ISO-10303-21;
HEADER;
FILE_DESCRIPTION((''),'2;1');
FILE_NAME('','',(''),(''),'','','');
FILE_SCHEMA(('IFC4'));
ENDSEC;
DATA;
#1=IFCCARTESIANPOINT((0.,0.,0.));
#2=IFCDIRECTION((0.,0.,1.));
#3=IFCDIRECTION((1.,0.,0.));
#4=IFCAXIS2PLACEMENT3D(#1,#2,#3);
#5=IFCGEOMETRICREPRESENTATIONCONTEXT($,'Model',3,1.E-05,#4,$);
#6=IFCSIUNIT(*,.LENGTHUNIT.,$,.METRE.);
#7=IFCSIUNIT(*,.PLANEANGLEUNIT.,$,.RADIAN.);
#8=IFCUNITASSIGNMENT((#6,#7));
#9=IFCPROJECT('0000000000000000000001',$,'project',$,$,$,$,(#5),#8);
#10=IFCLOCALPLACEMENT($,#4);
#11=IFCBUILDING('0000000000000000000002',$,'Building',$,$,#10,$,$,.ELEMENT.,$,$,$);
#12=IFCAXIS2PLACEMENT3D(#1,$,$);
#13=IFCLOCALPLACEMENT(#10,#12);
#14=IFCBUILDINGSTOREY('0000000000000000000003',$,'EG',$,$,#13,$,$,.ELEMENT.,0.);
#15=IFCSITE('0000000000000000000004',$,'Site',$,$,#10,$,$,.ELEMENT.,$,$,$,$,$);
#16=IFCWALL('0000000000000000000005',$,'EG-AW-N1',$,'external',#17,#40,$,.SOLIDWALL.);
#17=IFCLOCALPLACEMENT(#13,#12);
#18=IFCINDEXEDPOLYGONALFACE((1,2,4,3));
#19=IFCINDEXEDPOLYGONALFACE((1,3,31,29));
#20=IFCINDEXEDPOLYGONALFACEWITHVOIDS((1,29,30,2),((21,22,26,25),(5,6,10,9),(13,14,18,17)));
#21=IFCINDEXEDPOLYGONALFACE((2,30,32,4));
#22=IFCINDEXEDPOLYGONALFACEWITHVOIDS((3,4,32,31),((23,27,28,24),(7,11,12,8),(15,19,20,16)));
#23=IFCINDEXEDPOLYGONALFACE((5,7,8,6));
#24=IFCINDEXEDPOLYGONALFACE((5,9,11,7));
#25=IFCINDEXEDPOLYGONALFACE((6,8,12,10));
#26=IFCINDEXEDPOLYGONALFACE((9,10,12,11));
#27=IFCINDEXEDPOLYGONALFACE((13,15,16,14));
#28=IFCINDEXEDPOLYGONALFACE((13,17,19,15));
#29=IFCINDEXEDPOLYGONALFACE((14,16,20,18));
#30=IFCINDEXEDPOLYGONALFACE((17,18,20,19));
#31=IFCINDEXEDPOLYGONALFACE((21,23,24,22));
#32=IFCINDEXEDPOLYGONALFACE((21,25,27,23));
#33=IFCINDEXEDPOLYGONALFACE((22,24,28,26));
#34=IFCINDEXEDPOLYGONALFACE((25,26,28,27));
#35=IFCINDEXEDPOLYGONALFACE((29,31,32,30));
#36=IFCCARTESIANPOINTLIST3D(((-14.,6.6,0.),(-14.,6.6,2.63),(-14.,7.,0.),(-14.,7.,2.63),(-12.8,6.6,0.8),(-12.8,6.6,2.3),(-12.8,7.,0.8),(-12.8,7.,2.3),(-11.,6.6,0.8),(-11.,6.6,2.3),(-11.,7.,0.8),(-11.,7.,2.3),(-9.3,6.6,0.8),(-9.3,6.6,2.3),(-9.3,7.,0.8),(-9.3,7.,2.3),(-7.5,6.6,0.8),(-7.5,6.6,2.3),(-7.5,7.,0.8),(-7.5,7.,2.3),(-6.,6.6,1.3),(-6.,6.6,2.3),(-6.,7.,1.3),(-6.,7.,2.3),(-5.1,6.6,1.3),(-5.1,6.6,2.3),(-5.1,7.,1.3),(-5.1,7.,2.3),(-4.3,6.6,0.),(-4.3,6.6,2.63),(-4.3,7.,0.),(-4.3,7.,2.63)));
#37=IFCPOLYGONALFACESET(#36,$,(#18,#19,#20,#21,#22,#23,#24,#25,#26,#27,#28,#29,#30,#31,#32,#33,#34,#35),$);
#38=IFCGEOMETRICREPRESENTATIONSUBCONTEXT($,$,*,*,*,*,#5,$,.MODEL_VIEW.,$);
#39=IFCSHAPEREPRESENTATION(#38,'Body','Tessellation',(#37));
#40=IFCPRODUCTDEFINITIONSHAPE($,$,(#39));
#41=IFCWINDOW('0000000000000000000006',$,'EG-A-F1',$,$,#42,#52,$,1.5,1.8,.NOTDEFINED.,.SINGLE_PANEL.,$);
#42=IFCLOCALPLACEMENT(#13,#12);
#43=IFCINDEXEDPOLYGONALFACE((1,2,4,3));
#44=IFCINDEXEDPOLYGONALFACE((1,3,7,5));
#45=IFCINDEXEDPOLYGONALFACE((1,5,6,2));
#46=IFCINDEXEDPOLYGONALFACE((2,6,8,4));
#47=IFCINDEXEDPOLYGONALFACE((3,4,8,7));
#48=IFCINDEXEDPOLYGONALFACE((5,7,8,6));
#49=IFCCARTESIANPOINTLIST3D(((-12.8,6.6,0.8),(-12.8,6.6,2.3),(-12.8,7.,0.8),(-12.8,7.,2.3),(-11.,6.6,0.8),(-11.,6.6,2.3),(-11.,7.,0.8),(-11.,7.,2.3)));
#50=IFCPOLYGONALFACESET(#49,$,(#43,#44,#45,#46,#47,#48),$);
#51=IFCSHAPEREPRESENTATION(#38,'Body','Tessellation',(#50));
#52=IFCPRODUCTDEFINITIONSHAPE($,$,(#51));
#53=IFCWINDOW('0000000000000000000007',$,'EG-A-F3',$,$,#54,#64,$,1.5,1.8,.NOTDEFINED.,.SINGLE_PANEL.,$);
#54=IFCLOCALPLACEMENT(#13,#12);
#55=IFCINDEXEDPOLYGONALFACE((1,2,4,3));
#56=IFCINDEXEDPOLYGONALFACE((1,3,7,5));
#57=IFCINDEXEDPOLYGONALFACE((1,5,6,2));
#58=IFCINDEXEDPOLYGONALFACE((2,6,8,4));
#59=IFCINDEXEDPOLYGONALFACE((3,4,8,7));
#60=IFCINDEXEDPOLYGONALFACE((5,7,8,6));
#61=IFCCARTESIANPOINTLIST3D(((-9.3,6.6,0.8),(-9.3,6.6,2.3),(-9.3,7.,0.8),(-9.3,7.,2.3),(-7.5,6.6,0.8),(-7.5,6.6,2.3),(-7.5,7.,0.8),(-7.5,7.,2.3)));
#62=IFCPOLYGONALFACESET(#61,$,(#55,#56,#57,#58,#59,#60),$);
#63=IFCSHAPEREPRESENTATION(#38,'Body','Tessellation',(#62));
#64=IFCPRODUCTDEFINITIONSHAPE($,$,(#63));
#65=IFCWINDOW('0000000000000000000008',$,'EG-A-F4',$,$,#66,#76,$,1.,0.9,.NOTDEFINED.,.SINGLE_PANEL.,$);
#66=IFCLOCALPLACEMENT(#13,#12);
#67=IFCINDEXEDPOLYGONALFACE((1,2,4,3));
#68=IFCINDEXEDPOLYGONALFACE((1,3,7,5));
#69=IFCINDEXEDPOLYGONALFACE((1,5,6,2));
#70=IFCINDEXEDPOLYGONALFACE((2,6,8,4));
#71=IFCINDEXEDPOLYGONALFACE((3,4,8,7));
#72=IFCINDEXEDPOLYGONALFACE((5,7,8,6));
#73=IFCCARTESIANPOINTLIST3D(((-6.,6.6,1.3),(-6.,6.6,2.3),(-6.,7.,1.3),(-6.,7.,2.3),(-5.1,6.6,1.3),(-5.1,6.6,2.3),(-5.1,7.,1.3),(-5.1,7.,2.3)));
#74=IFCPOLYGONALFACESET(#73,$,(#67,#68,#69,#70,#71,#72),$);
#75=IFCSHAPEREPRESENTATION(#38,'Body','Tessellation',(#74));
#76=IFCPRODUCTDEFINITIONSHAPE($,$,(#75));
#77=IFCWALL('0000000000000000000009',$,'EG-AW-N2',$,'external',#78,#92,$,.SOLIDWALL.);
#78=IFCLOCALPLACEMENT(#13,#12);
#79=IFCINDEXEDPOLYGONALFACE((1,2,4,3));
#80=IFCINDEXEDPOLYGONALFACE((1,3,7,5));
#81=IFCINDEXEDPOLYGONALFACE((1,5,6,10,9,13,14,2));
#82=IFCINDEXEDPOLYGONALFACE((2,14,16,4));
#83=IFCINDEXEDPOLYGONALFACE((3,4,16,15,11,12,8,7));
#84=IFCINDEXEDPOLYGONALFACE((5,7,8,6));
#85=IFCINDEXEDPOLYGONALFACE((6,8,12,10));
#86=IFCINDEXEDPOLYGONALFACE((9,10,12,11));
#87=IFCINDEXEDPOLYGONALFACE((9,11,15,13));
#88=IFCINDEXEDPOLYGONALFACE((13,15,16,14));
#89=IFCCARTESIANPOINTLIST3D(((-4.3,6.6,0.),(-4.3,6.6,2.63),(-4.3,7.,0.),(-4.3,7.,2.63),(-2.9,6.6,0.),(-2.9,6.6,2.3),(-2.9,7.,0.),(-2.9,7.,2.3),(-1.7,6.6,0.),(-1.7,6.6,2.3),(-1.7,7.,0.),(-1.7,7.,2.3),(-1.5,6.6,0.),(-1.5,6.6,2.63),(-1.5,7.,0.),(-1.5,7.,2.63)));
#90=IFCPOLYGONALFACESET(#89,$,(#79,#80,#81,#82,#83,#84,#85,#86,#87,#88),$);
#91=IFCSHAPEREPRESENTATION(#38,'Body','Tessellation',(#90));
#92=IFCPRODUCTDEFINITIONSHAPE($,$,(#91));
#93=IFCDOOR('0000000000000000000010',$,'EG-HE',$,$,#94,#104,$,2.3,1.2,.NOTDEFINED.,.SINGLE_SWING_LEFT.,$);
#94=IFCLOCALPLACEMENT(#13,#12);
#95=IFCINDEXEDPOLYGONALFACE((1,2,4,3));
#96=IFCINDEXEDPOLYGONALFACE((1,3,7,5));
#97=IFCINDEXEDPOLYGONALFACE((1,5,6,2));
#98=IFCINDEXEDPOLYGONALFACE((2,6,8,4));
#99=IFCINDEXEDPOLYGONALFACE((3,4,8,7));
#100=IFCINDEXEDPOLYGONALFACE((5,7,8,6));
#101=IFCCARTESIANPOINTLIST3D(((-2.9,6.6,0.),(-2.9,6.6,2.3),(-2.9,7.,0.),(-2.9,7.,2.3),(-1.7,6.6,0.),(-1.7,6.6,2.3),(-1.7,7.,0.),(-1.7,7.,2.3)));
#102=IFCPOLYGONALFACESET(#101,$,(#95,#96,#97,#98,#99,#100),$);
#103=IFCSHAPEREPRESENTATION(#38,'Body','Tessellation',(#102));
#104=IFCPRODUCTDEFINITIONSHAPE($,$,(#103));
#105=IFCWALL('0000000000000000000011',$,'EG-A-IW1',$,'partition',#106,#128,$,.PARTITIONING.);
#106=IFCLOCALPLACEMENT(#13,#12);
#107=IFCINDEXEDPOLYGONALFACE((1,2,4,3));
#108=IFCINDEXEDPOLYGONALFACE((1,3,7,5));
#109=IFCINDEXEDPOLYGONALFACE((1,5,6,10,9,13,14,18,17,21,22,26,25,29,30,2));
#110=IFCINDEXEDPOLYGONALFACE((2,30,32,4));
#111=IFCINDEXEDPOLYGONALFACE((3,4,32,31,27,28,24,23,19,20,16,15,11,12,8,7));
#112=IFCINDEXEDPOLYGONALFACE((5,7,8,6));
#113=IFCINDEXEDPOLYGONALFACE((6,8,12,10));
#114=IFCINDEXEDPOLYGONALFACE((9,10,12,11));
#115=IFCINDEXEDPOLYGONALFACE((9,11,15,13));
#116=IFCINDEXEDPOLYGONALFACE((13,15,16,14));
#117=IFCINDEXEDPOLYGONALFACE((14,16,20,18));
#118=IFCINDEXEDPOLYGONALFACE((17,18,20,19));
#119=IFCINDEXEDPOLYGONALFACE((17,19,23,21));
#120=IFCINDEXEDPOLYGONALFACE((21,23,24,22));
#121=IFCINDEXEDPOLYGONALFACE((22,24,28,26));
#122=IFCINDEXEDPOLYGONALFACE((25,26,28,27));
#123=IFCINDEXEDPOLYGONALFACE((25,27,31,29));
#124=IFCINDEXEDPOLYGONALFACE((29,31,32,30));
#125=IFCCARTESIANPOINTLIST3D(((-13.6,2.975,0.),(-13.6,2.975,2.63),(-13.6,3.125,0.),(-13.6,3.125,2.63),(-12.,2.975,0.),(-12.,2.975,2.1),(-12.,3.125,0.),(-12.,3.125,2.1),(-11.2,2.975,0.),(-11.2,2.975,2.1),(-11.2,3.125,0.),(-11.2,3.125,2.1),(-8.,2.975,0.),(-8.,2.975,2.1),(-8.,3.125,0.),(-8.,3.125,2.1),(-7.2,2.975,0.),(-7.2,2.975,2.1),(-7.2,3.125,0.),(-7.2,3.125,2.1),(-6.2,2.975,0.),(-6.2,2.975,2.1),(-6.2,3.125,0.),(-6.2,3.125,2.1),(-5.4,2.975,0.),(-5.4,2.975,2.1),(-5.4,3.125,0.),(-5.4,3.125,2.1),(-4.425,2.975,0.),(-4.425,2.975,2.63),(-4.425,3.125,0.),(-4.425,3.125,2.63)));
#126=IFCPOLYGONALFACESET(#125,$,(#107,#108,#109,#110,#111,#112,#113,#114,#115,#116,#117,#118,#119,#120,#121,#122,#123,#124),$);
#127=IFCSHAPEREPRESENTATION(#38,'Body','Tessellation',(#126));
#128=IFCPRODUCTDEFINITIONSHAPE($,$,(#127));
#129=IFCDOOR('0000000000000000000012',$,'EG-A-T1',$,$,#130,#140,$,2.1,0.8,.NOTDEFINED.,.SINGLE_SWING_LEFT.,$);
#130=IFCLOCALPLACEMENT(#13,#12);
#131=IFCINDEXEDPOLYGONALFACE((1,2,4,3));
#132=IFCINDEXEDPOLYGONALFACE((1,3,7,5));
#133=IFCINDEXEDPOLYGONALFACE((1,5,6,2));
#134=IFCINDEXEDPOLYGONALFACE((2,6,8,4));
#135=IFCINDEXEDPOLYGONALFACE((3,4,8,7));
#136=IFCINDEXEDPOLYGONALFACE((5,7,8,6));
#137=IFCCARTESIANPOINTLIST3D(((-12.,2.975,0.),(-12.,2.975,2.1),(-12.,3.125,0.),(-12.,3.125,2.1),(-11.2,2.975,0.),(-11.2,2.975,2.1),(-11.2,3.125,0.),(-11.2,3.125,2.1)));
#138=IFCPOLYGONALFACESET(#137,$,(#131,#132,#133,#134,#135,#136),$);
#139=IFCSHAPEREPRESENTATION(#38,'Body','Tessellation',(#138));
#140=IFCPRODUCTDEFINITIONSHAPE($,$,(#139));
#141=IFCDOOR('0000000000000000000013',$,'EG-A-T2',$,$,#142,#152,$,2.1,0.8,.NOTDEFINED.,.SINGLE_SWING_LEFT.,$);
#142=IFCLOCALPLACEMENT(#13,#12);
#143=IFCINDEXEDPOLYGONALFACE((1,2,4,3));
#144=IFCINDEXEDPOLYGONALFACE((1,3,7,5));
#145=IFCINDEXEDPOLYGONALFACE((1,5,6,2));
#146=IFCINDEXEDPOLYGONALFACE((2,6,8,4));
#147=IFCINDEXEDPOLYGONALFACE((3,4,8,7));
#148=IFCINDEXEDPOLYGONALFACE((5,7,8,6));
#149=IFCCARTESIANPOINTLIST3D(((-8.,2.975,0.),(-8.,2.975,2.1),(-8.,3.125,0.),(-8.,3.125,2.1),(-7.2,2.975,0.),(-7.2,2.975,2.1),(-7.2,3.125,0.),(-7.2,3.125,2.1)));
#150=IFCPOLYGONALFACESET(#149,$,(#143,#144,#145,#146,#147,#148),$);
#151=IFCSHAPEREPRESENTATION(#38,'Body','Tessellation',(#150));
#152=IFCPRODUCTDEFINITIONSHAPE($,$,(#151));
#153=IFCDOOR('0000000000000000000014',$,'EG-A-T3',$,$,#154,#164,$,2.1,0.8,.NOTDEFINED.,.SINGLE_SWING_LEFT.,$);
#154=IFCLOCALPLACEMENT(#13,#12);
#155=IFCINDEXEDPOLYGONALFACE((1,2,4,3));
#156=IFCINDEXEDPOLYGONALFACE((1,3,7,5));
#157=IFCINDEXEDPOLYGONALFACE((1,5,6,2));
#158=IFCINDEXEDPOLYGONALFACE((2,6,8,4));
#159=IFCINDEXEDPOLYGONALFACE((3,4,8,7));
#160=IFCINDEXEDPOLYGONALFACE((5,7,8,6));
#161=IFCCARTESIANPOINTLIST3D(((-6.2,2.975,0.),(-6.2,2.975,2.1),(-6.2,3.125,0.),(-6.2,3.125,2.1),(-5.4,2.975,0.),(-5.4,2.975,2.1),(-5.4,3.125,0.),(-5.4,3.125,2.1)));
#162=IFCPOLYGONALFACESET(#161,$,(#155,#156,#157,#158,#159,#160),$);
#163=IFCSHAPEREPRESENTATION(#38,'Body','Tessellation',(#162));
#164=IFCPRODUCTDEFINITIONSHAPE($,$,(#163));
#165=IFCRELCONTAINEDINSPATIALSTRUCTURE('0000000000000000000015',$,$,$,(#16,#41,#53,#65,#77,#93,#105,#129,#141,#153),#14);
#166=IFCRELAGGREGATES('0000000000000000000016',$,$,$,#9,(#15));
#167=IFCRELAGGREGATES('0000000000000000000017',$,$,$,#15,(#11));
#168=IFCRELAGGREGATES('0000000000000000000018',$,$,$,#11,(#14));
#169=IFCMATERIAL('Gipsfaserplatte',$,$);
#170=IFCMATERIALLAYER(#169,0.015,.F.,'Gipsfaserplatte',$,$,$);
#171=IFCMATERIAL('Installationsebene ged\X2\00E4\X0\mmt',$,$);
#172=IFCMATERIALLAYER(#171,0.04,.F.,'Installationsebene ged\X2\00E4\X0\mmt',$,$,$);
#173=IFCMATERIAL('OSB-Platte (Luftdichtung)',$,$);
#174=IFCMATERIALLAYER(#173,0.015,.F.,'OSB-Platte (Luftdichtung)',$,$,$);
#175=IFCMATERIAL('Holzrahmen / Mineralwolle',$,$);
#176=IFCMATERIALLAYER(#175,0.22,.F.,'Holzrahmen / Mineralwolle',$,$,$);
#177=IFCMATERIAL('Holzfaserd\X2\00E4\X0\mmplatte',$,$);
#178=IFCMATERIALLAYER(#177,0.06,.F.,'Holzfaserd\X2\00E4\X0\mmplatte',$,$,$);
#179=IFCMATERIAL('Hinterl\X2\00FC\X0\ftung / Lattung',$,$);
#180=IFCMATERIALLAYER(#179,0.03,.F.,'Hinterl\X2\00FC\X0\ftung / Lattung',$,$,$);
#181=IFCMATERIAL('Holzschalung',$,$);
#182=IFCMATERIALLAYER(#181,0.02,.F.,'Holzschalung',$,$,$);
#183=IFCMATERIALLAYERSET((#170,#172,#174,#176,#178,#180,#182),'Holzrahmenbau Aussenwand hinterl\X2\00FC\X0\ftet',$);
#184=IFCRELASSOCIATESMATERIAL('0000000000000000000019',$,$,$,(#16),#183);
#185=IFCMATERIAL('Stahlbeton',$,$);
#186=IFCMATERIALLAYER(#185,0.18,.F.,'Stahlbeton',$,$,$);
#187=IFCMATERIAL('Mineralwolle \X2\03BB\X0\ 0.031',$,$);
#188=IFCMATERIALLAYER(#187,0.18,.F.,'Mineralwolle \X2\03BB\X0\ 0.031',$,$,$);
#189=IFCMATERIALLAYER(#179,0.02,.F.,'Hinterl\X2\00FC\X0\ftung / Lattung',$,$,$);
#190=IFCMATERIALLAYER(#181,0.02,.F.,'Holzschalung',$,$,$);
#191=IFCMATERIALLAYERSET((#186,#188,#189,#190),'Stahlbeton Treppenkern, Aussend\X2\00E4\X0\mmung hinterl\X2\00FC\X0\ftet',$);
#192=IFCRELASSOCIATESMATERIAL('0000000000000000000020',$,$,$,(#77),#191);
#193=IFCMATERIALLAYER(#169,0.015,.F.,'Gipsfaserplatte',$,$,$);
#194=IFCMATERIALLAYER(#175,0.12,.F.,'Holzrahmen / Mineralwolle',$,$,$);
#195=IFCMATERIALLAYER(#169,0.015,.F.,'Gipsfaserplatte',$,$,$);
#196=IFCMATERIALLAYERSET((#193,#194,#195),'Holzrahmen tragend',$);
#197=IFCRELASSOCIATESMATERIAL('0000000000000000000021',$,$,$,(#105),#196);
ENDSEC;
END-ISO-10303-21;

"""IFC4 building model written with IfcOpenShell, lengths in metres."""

from ifc_helpers import new_model, si_unit, frame, frame_2d, origin, origin_with_axes, place, context, subcontext, project, spatial, rectangle, extrude, material, layer, layer_set, element, fill, save


model = new_model("IFC4")

# Units and contexts
model_context = context("Model", 3, precision=1e-05, world=origin_with_axes())
sub_context = subcontext(model_context, None, None, "MODEL_VIEW")
ifc_project = project(units=[si_unit("LENGTHUNIT", "METRE"), si_unit("PLANEANGLEUNIT", "RADIAN")], contexts=[model_context])

# Site, building, storey
placement = place(None, origin_with_axes())
site = spatial("IfcSite", under=ifc_project, at=placement, Name="Site", CompositionType="ELEMENT")
building = spatial("IfcBuilding", under=site, at=placement, Name="Building", CompositionType="ELEMENT")
storey_placement = place(placement, origin())
storey = spatial("IfcBuildingStorey", under=building, at=storey_placement, Name="EG", CompositionType="ELEMENT", Elevation=0.0)

# Wall, openings, windows
ifc_material_1 = material(Name="Gipsfaserplatte")
ifc_layer_1 = layer(ifc_material_1, 0.015, ventilated=False, Name="Gipsfaserplatte")
ifc_material_2 = material(Name="Installationsebene gedämmt")
ifc_layer_2 = layer(ifc_material_2, 0.04, ventilated=False, Name="Installationsebene gedämmt")
ifc_material_3 = material(Name="OSB-Platte (Luftdichtung)")
ifc_layer_3 = layer(ifc_material_3, 0.015, ventilated=False, Name="OSB-Platte (Luftdichtung)")
ifc_material_4 = material(Name="Holzrahmen / Mineralwolle")
ifc_layer_4 = layer(ifc_material_4, 0.22, ventilated=False, Name="Holzrahmen / Mineralwolle")
ifc_material_5 = material(Name="Holzfaserdämmplatte")
ifc_layer_5 = layer(ifc_material_5, 0.06, ventilated=False, Name="Holzfaserdämmplatte")
ifc_material_6 = material(Name="Hinterlüftung / Lattung")
ifc_layer_6 = layer(ifc_material_6, 0.03, ventilated=False, Name="Hinterlüftung / Lattung")
ifc_material_7 = material(Name="Holzschalung")
ifc_layer_7 = layer(ifc_material_7, 0.02, ventilated=False, Name="Holzschalung")
ifc_layer_set_1 = layer_set([ifc_layer_1, ifc_layer_2, ifc_layer_3, ifc_layer_4, ifc_layer_5, ifc_layer_6, ifc_layer_7], Name="Holzrahmenbau Aussenwand hinterlüftet")
wall_1_placement = place(storey_placement, frame((-14.0, 6.8, 0.0), z_axis=(0.0, 0.0, 1.0), x_axis=(1.0, 0.0, 0.0)))
wall_1 = element("IfcWall", 1, at=wall_1_placement, inside=storey, material=ifc_layer_set_1, Name="EG-AW-N1", ObjectType="external", PredefinedType="SOLIDWALL", context=sub_context, shape_type="SweptSolid", body=[
    extrude(rectangle(XDim=9.7, YDim=0.4, at=frame_2d((4.85, 0.0))), origin(), (0.0, 0.0, 1.0), 2.63),
])
opening_1_placement = place(wall_1_placement, frame((2.1, 0.25, 0.8), z_axis=(0.0, -1.0, 0.0), x_axis=(1.0, 0.0, 0.0)))
opening_1 = element("IfcOpeningElement", 2, at=opening_1_placement, cuts=wall_1, PredefinedType="OPENING", context=sub_context, shape_type="SweptSolid", body=[
    extrude(rectangle(XDim=1.8, YDim=1.5, at=frame_2d((0.0, 0.75))), origin(), (0.0, 0.0, 1.0), 0.5),
])
opening_2_placement = place(wall_1_placement, frame((5.6, 0.25, 0.8), z_axis=(0.0, -1.0, 0.0), x_axis=(1.0, 0.0, 0.0)))
opening_2 = element("IfcOpeningElement", 3, at=opening_2_placement, cuts=wall_1, PredefinedType="OPENING", context=sub_context, shape_type="SweptSolid", body=[
    extrude(rectangle(XDim=1.8, YDim=1.5, at=frame_2d((0.0, 0.75))), origin(), (0.0, 0.0, 1.0), 0.5),
])
opening_3_placement = place(wall_1_placement, frame((8.45, 0.25, 1.3), z_axis=(0.0, -1.0, 0.0), x_axis=(1.0, 0.0, 0.0)))
opening_3 = element("IfcOpeningElement", 4, at=opening_3_placement, cuts=wall_1, PredefinedType="OPENING", context=sub_context, shape_type="SweptSolid", body=[
    extrude(rectangle(XDim=0.9, YDim=1.0, at=frame_2d((0.0, 0.5))), origin(), (0.0, 0.0, 1.0), 0.5),
])
window_1_placement = place(wall_1_placement, frame((2.1, 0.2, 0.8), z_axis=(0.0, -1.0, 0.0), x_axis=(1.0, 0.0, 0.0)))
window_1 = element("IfcWindow", 5, at=window_1_placement, inside=storey, Name="EG-A-F1", OverallHeight=1.5, OverallWidth=1.8, PartitioningType="SINGLE_PANEL", PredefinedType="NOTDEFINED", context=sub_context, shape_type="SweptSolid", body=[
    extrude(rectangle(XDim=1.8, YDim=1.5, at=frame_2d((0.0, 0.75))), origin(), (0.0, 0.0, 1.0), 0.4),
])
fill(opening_1, window_1)
window_2_placement = place(wall_1_placement, frame((5.6, 0.2, 0.8), z_axis=(0.0, -1.0, 0.0), x_axis=(1.0, 0.0, 0.0)))
window_2 = element("IfcWindow", 6, at=window_2_placement, inside=storey, Name="EG-A-F3", OverallHeight=1.5, OverallWidth=1.8, PartitioningType="SINGLE_PANEL", PredefinedType="NOTDEFINED", context=sub_context, shape_type="SweptSolid", body=[
    extrude(rectangle(XDim=1.8, YDim=1.5, at=frame_2d((0.0, 0.75))), origin(), (0.0, 0.0, 1.0), 0.4),
])
fill(opening_2, window_2)
window_3_placement = place(wall_1_placement, frame((8.45, 0.2, 1.3), z_axis=(0.0, -1.0, 0.0), x_axis=(1.0, 0.0, 0.0)))
window_3 = element("IfcWindow", 7, at=window_3_placement, inside=storey, Name="EG-A-F4", OverallHeight=1.0, OverallWidth=0.9, PartitioningType="SINGLE_PANEL", PredefinedType="NOTDEFINED", context=sub_context, shape_type="SweptSolid", body=[
    extrude(rectangle(XDim=0.9, YDim=1.0, at=frame_2d((0.0, 0.5))), origin(), (0.0, 0.0, 1.0), 0.4),
])
fill(opening_3, window_3)

# Wall, opening, door
ifc_material_8 = material(Name="Stahlbeton")
ifc_layer_8 = layer(ifc_material_8, 0.18, ventilated=False, Name="Stahlbeton")
ifc_material_9 = material(Name="Mineralwolle λ 0.031")
ifc_layer_9 = layer(ifc_material_9, 0.18, ventilated=False, Name="Mineralwolle λ 0.031")
ifc_layer_10 = layer(ifc_material_6, 0.02, ventilated=False, Name="Hinterlüftung / Lattung")
ifc_layer_11 = layer(ifc_material_7, 0.02, ventilated=False, Name="Holzschalung")
ifc_layer_set_2 = layer_set([ifc_layer_8, ifc_layer_9, ifc_layer_10, ifc_layer_11], Name="Stahlbeton Treppenkern, Aussendämmung hinterlüftet")
wall_2_placement = place(storey_placement, frame((-4.3, 6.8, 0.0), z_axis=(0.0, 0.0, 1.0), x_axis=(1.0, 0.0, 0.0)))
wall_2 = element("IfcWall", 8, at=wall_2_placement, inside=storey, material=ifc_layer_set_2, Name="EG-AW-N2", ObjectType="external", PredefinedType="SOLIDWALL", context=sub_context, shape_type="SweptSolid", body=[
    extrude(rectangle(XDim=2.8, YDim=0.4, at=frame_2d((1.4, 0.0))), origin(), (0.0, 0.0, 1.0), 2.63),
])
opening_4_placement = place(wall_2_placement, frame((2.0, 0.25, 0.0), z_axis=(0.0, -1.0, 0.0), x_axis=(1.0, 0.0, 0.0)))
opening_4 = element("IfcOpeningElement", 9, at=opening_4_placement, cuts=wall_2, PredefinedType="OPENING", context=sub_context, shape_type="SweptSolid", body=[
    extrude(rectangle(XDim=1.2, YDim=2.3, at=frame_2d((0.0, 1.15))), origin(), (0.0, 0.0, 1.0), 0.5),
])
door_1_placement = place(wall_2_placement, frame((2.0, 0.2, 0.0), z_axis=(0.0, -1.0, 0.0), x_axis=(1.0, 0.0, 0.0)))
door_1 = element("IfcDoor", 10, at=door_1_placement, inside=storey, Name="EG-HE", OperationType="SINGLE_SWING_LEFT", OverallHeight=2.3, OverallWidth=1.2, PredefinedType="NOTDEFINED", context=sub_context, shape_type="SweptSolid", body=[
    extrude(rectangle(XDim=1.2, YDim=2.3, at=frame_2d((0.0, 1.15))), origin(), (0.0, 0.0, 1.0), 0.4),
])
fill(opening_4, door_1)

# Wall, openings, doors
ifc_layer_12 = layer(ifc_material_1, 0.015, ventilated=False, Name="Gipsfaserplatte")
ifc_layer_13 = layer(ifc_material_4, 0.12, ventilated=False, Name="Holzrahmen / Mineralwolle")
ifc_layer_14 = layer(ifc_material_1, 0.015, ventilated=False, Name="Gipsfaserplatte")
ifc_layer_set_3 = layer_set([ifc_layer_12, ifc_layer_13, ifc_layer_14], Name="Holzrahmen tragend")
wall_3_placement = place(storey_placement, frame((-13.6, 3.05, 0.0), z_axis=(0.0, 0.0, 1.0), x_axis=(1.0, 0.0, 0.0)))
wall_3 = element("IfcWall", 11, at=wall_3_placement, inside=storey, material=ifc_layer_set_3, Name="EG-A-IW1", ObjectType="partition", PredefinedType="PARTITIONING", context=sub_context, shape_type="SweptSolid", body=[
    extrude(rectangle(XDim=9.175, YDim=0.15, at=frame_2d((4.5875, 0.0))), origin(), (0.0, 0.0, 1.0), 2.63),
])
opening_5_placement = place(wall_3_placement, frame((2.0, 0.125, 0.0), z_axis=(0.0, -1.0, 0.0), x_axis=(1.0, 0.0, 0.0)))
opening_5 = element("IfcOpeningElement", 12, at=opening_5_placement, cuts=wall_3, PredefinedType="OPENING", context=sub_context, shape_type="SweptSolid", body=[
    extrude(rectangle(XDim=0.8, YDim=2.1, at=frame_2d((0.0, 1.05))), origin(), (0.0, 0.0, 1.0), 0.25),
])
opening_6_placement = place(wall_3_placement, frame((6.0, 0.125, 0.0), z_axis=(0.0, -1.0, 0.0), x_axis=(1.0, 0.0, 0.0)))
opening_6 = element("IfcOpeningElement", 13, at=opening_6_placement, cuts=wall_3, PredefinedType="OPENING", context=sub_context, shape_type="SweptSolid", body=[
    extrude(rectangle(XDim=0.8, YDim=2.1, at=frame_2d((0.0, 1.05))), origin(), (0.0, 0.0, 1.0), 0.25),
])
opening_7_placement = place(wall_3_placement, frame((7.8, 0.125, 0.0), z_axis=(0.0, -1.0, 0.0), x_axis=(1.0, 0.0, 0.0)))
opening_7 = element("IfcOpeningElement", 14, at=opening_7_placement, cuts=wall_3, PredefinedType="OPENING", context=sub_context, shape_type="SweptSolid", body=[
    extrude(rectangle(XDim=0.8, YDim=2.1, at=frame_2d((0.0, 1.05))), origin(), (0.0, 0.0, 1.0), 0.25),
])
door_2_placement = place(wall_3_placement, frame((2.0, 0.075, 0.0), z_axis=(0.0, -1.0, 0.0), x_axis=(1.0, 0.0, 0.0)))
door_2 = element("IfcDoor", 15, at=door_2_placement, inside=storey, Name="EG-A-T1", OperationType="SINGLE_SWING_LEFT", OverallHeight=2.1, OverallWidth=0.8, PredefinedType="NOTDEFINED", context=sub_context, shape_type="SweptSolid", body=[
    extrude(rectangle(XDim=0.8, YDim=2.1, at=frame_2d((0.0, 1.05))), origin(), (0.0, 0.0, 1.0), 0.15),
])
fill(opening_5, door_2)
door_3_placement = place(wall_3_placement, frame((6.0, 0.075, 0.0), z_axis=(0.0, -1.0, 0.0), x_axis=(1.0, 0.0, 0.0)))
door_3 = element("IfcDoor", 16, at=door_3_placement, inside=storey, Name="EG-A-T2", OperationType="SINGLE_SWING_LEFT", OverallHeight=2.1, OverallWidth=0.8, PredefinedType="NOTDEFINED", context=sub_context, shape_type="SweptSolid", body=[
    extrude(rectangle(XDim=0.8, YDim=2.1, at=frame_2d((0.0, 1.05))), origin(), (0.0, 0.0, 1.0), 0.15),
])
fill(opening_6, door_3)
door_4_placement = place(wall_3_placement, frame((7.8, 0.075, 0.0), z_axis=(0.0, -1.0, 0.0), x_axis=(1.0, 0.0, 0.0)))
door_4 = element("IfcDoor", 17, at=door_4_placement, inside=storey, Name="EG-A-T3", OperationType="SINGLE_SWING_LEFT", OverallHeight=2.1, OverallWidth=0.8, PredefinedType="NOTDEFINED", context=sub_context, shape_type="SweptSolid", body=[
    extrude(rectangle(XDim=0.8, YDim=2.1, at=frame_2d((0.0, 1.05))), origin(), (0.0, 0.0, 1.0), 0.15),
])
fill(opening_7, door_4)

save(model, "model.ifc")
